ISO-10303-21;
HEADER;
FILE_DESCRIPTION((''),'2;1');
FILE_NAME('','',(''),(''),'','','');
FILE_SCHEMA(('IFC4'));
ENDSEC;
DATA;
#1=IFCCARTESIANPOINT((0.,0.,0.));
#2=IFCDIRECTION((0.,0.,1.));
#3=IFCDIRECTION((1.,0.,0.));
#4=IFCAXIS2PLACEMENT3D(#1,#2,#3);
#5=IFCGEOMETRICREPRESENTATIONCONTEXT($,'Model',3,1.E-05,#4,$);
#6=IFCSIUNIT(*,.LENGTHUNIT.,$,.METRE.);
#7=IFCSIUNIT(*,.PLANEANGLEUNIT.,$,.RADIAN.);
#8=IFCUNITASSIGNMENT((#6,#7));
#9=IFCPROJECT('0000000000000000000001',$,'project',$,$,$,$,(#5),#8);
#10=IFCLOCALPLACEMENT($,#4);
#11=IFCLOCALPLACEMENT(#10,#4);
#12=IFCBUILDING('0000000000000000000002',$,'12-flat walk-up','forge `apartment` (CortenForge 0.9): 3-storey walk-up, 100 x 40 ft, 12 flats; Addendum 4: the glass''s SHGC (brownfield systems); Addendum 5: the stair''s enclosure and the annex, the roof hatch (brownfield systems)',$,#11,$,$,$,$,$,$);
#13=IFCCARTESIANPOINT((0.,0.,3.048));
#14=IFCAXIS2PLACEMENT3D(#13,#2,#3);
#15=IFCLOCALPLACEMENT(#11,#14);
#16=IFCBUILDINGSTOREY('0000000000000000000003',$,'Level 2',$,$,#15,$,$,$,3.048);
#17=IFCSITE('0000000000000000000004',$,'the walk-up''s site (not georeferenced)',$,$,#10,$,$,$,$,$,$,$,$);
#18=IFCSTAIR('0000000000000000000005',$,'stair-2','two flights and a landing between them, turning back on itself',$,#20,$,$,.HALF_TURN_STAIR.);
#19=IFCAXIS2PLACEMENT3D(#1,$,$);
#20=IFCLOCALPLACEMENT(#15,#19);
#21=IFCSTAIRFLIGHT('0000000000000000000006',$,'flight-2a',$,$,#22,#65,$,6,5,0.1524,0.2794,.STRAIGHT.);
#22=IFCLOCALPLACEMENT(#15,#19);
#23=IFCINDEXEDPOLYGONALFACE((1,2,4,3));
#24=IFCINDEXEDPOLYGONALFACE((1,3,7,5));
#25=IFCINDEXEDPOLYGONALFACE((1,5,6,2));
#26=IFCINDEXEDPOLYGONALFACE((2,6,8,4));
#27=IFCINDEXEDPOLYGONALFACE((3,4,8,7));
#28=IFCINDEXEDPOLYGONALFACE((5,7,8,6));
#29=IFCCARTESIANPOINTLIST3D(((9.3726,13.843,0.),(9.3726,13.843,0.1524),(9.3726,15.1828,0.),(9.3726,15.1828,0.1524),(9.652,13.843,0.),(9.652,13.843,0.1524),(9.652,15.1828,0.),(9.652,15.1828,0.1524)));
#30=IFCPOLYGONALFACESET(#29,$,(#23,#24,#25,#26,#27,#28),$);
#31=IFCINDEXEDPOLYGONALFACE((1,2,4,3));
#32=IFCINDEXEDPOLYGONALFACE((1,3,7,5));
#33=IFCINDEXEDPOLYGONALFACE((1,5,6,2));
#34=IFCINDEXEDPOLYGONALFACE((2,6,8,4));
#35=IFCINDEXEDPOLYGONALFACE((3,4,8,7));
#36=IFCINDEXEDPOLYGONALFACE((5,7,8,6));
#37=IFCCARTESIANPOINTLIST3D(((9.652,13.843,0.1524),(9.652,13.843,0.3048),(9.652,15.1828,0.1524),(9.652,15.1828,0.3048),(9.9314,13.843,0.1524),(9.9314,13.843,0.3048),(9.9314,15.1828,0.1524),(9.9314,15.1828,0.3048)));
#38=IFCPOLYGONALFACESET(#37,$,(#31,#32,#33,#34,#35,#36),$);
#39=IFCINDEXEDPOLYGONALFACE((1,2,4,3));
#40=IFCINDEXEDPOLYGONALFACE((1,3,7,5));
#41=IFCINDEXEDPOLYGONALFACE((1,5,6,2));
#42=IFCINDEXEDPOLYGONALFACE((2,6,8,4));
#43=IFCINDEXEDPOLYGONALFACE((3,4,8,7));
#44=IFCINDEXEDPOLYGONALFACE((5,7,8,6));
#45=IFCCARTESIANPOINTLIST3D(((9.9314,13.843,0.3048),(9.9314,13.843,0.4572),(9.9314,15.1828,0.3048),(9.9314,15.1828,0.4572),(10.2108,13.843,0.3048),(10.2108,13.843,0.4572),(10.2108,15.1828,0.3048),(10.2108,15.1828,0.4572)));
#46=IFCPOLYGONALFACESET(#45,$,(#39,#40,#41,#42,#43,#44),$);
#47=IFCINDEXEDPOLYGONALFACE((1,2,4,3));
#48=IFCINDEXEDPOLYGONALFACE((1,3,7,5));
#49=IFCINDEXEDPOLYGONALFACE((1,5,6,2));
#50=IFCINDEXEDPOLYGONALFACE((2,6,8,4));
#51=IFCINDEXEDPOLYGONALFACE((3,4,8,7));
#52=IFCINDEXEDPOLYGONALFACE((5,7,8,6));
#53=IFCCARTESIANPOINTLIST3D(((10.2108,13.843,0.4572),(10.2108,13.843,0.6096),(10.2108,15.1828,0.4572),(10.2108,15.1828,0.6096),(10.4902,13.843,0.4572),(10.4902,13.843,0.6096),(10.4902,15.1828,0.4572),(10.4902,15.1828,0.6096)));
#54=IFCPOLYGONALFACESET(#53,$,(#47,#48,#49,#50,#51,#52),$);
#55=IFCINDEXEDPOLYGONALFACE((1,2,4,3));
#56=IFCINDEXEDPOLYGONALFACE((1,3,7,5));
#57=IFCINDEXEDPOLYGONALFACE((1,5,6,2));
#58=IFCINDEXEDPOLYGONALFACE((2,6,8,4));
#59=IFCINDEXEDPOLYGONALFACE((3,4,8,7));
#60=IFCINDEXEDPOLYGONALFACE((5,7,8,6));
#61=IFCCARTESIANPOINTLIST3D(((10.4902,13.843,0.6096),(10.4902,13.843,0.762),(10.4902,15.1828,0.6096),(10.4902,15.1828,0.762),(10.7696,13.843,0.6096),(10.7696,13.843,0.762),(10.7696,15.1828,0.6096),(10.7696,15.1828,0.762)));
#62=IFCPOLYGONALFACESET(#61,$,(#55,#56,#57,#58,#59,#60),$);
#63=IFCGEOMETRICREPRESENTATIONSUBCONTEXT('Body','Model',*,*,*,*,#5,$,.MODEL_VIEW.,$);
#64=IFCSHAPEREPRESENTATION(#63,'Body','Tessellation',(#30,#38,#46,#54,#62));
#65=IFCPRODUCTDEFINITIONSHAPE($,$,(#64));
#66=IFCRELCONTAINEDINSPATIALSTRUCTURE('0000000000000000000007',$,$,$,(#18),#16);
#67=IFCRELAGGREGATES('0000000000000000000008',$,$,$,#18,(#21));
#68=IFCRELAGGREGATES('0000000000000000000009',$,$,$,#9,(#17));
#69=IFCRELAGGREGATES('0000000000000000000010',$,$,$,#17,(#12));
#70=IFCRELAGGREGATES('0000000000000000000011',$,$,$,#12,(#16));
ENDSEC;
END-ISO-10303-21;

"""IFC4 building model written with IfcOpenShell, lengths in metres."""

from ifc_helpers import new_model, si_unit, frame, frame_2d, origin, origin_with_axes, place, context, subcontext, project, spatial, rectangle, extrude, element, aggregate, save


model = new_model("IFC4")

# Units and contexts
model_context = context("Model", 3, precision=1e-05, world=origin_with_axes())
body_context = subcontext(model_context, "Body", "Model", "MODEL_VIEW")
ifc_project = project(units=[si_unit("LENGTHUNIT", "METRE"), si_unit("PLANEANGLEUNIT", "RADIAN")], contexts=[model_context])

# Site, building, storey
site_placement = place(None, origin_with_axes())
site = spatial("IfcSite", under=ifc_project, at=site_placement, Name="the walk-up's site (not georeferenced)")
building_placement = place(site_placement, origin_with_axes())
building = spatial("IfcBuilding", under=site, at=building_placement, Name="12-flat walk-up", Description="forge `apartment` (CortenForge 0.9): 3-storey walk-up, 100 x 40 ft, 12 flats; Addendum 4: the glass's SHGC (brownfield systems); Addendum 5: the stair's enclosure and the annex, the roof hatch (brownfield systems)")
storey_placement = place(building_placement, frame((0.0, 0.0, 3.048), z_axis=(0.0, 0.0, 1.0), x_axis=(1.0, 0.0, 0.0)))
storey = spatial("IfcBuildingStorey", under=building, at=storey_placement, Name="Level 2", Elevation=3.048)

# Stair
stair_placement = place(storey_placement, frame((0.0, 0.0, -3.048), z_axis=(0.0, 0.0, 1.0), x_axis=(1.0, 0.0, 0.0)))
stair = element("IfcStair", 1, at=stair_placement, inside=storey, Name="stair-2", Description="two flights and a landing between them, turning back on itself", PredefinedType="HALF_TURN_STAIR")

# Stair flight
stair_flight_placement = place(stair_placement, frame((9.3726, 13.843, 3.048), z_axis=(0.0, 0.0, 1.0), x_axis=(1.0, 0.0, 0.0)))
stair_flight = element("IfcStairFlight", 2, at=stair_flight_placement, Name="flight-2a", NumberOfRisers=6, NumberOfTreads=5, PredefinedType="STRAIGHT", RiserHeight=0.1524, TreadLength=0.2794, context=body_context, shape_type="SweptSolid", body=[
    extrude(rectangle(XDim=0.2794, YDim=1.3399, at=frame_2d((0.1397, 0.6699))), origin(), (0.0, 0.0, 1.0), 0.1524),
    extrude(rectangle(XDim=0.2794, YDim=1.3399, at=frame_2d((0.1397, 0.6699))), frame((0.2794, 0.0, 0.1524)), (0.0, 0.0, 1.0), 0.1524),
    extrude(rectangle(XDim=0.2794, YDim=1.3399, at=frame_2d((0.1397, 0.6699))), frame((0.5588, 0.0, 0.3048)), (0.0, 0.0, 1.0), 0.1524),
    extrude(rectangle(XDim=0.2794, YDim=1.3399, at=frame_2d((0.1397, 0.6699))), frame((0.8382, 0.0, 0.4572)), (0.0, 0.0, 1.0), 0.1524),
    extrude(rectangle(XDim=0.2794, YDim=1.3399, at=frame_2d((0.1397, 0.6699))), frame((1.1176, 0.0, 0.6096)), (0.0, 0.0, 1.0), 0.1524),
])
aggregate(stair, [stair_flight])

save(model, "model.ifc")
